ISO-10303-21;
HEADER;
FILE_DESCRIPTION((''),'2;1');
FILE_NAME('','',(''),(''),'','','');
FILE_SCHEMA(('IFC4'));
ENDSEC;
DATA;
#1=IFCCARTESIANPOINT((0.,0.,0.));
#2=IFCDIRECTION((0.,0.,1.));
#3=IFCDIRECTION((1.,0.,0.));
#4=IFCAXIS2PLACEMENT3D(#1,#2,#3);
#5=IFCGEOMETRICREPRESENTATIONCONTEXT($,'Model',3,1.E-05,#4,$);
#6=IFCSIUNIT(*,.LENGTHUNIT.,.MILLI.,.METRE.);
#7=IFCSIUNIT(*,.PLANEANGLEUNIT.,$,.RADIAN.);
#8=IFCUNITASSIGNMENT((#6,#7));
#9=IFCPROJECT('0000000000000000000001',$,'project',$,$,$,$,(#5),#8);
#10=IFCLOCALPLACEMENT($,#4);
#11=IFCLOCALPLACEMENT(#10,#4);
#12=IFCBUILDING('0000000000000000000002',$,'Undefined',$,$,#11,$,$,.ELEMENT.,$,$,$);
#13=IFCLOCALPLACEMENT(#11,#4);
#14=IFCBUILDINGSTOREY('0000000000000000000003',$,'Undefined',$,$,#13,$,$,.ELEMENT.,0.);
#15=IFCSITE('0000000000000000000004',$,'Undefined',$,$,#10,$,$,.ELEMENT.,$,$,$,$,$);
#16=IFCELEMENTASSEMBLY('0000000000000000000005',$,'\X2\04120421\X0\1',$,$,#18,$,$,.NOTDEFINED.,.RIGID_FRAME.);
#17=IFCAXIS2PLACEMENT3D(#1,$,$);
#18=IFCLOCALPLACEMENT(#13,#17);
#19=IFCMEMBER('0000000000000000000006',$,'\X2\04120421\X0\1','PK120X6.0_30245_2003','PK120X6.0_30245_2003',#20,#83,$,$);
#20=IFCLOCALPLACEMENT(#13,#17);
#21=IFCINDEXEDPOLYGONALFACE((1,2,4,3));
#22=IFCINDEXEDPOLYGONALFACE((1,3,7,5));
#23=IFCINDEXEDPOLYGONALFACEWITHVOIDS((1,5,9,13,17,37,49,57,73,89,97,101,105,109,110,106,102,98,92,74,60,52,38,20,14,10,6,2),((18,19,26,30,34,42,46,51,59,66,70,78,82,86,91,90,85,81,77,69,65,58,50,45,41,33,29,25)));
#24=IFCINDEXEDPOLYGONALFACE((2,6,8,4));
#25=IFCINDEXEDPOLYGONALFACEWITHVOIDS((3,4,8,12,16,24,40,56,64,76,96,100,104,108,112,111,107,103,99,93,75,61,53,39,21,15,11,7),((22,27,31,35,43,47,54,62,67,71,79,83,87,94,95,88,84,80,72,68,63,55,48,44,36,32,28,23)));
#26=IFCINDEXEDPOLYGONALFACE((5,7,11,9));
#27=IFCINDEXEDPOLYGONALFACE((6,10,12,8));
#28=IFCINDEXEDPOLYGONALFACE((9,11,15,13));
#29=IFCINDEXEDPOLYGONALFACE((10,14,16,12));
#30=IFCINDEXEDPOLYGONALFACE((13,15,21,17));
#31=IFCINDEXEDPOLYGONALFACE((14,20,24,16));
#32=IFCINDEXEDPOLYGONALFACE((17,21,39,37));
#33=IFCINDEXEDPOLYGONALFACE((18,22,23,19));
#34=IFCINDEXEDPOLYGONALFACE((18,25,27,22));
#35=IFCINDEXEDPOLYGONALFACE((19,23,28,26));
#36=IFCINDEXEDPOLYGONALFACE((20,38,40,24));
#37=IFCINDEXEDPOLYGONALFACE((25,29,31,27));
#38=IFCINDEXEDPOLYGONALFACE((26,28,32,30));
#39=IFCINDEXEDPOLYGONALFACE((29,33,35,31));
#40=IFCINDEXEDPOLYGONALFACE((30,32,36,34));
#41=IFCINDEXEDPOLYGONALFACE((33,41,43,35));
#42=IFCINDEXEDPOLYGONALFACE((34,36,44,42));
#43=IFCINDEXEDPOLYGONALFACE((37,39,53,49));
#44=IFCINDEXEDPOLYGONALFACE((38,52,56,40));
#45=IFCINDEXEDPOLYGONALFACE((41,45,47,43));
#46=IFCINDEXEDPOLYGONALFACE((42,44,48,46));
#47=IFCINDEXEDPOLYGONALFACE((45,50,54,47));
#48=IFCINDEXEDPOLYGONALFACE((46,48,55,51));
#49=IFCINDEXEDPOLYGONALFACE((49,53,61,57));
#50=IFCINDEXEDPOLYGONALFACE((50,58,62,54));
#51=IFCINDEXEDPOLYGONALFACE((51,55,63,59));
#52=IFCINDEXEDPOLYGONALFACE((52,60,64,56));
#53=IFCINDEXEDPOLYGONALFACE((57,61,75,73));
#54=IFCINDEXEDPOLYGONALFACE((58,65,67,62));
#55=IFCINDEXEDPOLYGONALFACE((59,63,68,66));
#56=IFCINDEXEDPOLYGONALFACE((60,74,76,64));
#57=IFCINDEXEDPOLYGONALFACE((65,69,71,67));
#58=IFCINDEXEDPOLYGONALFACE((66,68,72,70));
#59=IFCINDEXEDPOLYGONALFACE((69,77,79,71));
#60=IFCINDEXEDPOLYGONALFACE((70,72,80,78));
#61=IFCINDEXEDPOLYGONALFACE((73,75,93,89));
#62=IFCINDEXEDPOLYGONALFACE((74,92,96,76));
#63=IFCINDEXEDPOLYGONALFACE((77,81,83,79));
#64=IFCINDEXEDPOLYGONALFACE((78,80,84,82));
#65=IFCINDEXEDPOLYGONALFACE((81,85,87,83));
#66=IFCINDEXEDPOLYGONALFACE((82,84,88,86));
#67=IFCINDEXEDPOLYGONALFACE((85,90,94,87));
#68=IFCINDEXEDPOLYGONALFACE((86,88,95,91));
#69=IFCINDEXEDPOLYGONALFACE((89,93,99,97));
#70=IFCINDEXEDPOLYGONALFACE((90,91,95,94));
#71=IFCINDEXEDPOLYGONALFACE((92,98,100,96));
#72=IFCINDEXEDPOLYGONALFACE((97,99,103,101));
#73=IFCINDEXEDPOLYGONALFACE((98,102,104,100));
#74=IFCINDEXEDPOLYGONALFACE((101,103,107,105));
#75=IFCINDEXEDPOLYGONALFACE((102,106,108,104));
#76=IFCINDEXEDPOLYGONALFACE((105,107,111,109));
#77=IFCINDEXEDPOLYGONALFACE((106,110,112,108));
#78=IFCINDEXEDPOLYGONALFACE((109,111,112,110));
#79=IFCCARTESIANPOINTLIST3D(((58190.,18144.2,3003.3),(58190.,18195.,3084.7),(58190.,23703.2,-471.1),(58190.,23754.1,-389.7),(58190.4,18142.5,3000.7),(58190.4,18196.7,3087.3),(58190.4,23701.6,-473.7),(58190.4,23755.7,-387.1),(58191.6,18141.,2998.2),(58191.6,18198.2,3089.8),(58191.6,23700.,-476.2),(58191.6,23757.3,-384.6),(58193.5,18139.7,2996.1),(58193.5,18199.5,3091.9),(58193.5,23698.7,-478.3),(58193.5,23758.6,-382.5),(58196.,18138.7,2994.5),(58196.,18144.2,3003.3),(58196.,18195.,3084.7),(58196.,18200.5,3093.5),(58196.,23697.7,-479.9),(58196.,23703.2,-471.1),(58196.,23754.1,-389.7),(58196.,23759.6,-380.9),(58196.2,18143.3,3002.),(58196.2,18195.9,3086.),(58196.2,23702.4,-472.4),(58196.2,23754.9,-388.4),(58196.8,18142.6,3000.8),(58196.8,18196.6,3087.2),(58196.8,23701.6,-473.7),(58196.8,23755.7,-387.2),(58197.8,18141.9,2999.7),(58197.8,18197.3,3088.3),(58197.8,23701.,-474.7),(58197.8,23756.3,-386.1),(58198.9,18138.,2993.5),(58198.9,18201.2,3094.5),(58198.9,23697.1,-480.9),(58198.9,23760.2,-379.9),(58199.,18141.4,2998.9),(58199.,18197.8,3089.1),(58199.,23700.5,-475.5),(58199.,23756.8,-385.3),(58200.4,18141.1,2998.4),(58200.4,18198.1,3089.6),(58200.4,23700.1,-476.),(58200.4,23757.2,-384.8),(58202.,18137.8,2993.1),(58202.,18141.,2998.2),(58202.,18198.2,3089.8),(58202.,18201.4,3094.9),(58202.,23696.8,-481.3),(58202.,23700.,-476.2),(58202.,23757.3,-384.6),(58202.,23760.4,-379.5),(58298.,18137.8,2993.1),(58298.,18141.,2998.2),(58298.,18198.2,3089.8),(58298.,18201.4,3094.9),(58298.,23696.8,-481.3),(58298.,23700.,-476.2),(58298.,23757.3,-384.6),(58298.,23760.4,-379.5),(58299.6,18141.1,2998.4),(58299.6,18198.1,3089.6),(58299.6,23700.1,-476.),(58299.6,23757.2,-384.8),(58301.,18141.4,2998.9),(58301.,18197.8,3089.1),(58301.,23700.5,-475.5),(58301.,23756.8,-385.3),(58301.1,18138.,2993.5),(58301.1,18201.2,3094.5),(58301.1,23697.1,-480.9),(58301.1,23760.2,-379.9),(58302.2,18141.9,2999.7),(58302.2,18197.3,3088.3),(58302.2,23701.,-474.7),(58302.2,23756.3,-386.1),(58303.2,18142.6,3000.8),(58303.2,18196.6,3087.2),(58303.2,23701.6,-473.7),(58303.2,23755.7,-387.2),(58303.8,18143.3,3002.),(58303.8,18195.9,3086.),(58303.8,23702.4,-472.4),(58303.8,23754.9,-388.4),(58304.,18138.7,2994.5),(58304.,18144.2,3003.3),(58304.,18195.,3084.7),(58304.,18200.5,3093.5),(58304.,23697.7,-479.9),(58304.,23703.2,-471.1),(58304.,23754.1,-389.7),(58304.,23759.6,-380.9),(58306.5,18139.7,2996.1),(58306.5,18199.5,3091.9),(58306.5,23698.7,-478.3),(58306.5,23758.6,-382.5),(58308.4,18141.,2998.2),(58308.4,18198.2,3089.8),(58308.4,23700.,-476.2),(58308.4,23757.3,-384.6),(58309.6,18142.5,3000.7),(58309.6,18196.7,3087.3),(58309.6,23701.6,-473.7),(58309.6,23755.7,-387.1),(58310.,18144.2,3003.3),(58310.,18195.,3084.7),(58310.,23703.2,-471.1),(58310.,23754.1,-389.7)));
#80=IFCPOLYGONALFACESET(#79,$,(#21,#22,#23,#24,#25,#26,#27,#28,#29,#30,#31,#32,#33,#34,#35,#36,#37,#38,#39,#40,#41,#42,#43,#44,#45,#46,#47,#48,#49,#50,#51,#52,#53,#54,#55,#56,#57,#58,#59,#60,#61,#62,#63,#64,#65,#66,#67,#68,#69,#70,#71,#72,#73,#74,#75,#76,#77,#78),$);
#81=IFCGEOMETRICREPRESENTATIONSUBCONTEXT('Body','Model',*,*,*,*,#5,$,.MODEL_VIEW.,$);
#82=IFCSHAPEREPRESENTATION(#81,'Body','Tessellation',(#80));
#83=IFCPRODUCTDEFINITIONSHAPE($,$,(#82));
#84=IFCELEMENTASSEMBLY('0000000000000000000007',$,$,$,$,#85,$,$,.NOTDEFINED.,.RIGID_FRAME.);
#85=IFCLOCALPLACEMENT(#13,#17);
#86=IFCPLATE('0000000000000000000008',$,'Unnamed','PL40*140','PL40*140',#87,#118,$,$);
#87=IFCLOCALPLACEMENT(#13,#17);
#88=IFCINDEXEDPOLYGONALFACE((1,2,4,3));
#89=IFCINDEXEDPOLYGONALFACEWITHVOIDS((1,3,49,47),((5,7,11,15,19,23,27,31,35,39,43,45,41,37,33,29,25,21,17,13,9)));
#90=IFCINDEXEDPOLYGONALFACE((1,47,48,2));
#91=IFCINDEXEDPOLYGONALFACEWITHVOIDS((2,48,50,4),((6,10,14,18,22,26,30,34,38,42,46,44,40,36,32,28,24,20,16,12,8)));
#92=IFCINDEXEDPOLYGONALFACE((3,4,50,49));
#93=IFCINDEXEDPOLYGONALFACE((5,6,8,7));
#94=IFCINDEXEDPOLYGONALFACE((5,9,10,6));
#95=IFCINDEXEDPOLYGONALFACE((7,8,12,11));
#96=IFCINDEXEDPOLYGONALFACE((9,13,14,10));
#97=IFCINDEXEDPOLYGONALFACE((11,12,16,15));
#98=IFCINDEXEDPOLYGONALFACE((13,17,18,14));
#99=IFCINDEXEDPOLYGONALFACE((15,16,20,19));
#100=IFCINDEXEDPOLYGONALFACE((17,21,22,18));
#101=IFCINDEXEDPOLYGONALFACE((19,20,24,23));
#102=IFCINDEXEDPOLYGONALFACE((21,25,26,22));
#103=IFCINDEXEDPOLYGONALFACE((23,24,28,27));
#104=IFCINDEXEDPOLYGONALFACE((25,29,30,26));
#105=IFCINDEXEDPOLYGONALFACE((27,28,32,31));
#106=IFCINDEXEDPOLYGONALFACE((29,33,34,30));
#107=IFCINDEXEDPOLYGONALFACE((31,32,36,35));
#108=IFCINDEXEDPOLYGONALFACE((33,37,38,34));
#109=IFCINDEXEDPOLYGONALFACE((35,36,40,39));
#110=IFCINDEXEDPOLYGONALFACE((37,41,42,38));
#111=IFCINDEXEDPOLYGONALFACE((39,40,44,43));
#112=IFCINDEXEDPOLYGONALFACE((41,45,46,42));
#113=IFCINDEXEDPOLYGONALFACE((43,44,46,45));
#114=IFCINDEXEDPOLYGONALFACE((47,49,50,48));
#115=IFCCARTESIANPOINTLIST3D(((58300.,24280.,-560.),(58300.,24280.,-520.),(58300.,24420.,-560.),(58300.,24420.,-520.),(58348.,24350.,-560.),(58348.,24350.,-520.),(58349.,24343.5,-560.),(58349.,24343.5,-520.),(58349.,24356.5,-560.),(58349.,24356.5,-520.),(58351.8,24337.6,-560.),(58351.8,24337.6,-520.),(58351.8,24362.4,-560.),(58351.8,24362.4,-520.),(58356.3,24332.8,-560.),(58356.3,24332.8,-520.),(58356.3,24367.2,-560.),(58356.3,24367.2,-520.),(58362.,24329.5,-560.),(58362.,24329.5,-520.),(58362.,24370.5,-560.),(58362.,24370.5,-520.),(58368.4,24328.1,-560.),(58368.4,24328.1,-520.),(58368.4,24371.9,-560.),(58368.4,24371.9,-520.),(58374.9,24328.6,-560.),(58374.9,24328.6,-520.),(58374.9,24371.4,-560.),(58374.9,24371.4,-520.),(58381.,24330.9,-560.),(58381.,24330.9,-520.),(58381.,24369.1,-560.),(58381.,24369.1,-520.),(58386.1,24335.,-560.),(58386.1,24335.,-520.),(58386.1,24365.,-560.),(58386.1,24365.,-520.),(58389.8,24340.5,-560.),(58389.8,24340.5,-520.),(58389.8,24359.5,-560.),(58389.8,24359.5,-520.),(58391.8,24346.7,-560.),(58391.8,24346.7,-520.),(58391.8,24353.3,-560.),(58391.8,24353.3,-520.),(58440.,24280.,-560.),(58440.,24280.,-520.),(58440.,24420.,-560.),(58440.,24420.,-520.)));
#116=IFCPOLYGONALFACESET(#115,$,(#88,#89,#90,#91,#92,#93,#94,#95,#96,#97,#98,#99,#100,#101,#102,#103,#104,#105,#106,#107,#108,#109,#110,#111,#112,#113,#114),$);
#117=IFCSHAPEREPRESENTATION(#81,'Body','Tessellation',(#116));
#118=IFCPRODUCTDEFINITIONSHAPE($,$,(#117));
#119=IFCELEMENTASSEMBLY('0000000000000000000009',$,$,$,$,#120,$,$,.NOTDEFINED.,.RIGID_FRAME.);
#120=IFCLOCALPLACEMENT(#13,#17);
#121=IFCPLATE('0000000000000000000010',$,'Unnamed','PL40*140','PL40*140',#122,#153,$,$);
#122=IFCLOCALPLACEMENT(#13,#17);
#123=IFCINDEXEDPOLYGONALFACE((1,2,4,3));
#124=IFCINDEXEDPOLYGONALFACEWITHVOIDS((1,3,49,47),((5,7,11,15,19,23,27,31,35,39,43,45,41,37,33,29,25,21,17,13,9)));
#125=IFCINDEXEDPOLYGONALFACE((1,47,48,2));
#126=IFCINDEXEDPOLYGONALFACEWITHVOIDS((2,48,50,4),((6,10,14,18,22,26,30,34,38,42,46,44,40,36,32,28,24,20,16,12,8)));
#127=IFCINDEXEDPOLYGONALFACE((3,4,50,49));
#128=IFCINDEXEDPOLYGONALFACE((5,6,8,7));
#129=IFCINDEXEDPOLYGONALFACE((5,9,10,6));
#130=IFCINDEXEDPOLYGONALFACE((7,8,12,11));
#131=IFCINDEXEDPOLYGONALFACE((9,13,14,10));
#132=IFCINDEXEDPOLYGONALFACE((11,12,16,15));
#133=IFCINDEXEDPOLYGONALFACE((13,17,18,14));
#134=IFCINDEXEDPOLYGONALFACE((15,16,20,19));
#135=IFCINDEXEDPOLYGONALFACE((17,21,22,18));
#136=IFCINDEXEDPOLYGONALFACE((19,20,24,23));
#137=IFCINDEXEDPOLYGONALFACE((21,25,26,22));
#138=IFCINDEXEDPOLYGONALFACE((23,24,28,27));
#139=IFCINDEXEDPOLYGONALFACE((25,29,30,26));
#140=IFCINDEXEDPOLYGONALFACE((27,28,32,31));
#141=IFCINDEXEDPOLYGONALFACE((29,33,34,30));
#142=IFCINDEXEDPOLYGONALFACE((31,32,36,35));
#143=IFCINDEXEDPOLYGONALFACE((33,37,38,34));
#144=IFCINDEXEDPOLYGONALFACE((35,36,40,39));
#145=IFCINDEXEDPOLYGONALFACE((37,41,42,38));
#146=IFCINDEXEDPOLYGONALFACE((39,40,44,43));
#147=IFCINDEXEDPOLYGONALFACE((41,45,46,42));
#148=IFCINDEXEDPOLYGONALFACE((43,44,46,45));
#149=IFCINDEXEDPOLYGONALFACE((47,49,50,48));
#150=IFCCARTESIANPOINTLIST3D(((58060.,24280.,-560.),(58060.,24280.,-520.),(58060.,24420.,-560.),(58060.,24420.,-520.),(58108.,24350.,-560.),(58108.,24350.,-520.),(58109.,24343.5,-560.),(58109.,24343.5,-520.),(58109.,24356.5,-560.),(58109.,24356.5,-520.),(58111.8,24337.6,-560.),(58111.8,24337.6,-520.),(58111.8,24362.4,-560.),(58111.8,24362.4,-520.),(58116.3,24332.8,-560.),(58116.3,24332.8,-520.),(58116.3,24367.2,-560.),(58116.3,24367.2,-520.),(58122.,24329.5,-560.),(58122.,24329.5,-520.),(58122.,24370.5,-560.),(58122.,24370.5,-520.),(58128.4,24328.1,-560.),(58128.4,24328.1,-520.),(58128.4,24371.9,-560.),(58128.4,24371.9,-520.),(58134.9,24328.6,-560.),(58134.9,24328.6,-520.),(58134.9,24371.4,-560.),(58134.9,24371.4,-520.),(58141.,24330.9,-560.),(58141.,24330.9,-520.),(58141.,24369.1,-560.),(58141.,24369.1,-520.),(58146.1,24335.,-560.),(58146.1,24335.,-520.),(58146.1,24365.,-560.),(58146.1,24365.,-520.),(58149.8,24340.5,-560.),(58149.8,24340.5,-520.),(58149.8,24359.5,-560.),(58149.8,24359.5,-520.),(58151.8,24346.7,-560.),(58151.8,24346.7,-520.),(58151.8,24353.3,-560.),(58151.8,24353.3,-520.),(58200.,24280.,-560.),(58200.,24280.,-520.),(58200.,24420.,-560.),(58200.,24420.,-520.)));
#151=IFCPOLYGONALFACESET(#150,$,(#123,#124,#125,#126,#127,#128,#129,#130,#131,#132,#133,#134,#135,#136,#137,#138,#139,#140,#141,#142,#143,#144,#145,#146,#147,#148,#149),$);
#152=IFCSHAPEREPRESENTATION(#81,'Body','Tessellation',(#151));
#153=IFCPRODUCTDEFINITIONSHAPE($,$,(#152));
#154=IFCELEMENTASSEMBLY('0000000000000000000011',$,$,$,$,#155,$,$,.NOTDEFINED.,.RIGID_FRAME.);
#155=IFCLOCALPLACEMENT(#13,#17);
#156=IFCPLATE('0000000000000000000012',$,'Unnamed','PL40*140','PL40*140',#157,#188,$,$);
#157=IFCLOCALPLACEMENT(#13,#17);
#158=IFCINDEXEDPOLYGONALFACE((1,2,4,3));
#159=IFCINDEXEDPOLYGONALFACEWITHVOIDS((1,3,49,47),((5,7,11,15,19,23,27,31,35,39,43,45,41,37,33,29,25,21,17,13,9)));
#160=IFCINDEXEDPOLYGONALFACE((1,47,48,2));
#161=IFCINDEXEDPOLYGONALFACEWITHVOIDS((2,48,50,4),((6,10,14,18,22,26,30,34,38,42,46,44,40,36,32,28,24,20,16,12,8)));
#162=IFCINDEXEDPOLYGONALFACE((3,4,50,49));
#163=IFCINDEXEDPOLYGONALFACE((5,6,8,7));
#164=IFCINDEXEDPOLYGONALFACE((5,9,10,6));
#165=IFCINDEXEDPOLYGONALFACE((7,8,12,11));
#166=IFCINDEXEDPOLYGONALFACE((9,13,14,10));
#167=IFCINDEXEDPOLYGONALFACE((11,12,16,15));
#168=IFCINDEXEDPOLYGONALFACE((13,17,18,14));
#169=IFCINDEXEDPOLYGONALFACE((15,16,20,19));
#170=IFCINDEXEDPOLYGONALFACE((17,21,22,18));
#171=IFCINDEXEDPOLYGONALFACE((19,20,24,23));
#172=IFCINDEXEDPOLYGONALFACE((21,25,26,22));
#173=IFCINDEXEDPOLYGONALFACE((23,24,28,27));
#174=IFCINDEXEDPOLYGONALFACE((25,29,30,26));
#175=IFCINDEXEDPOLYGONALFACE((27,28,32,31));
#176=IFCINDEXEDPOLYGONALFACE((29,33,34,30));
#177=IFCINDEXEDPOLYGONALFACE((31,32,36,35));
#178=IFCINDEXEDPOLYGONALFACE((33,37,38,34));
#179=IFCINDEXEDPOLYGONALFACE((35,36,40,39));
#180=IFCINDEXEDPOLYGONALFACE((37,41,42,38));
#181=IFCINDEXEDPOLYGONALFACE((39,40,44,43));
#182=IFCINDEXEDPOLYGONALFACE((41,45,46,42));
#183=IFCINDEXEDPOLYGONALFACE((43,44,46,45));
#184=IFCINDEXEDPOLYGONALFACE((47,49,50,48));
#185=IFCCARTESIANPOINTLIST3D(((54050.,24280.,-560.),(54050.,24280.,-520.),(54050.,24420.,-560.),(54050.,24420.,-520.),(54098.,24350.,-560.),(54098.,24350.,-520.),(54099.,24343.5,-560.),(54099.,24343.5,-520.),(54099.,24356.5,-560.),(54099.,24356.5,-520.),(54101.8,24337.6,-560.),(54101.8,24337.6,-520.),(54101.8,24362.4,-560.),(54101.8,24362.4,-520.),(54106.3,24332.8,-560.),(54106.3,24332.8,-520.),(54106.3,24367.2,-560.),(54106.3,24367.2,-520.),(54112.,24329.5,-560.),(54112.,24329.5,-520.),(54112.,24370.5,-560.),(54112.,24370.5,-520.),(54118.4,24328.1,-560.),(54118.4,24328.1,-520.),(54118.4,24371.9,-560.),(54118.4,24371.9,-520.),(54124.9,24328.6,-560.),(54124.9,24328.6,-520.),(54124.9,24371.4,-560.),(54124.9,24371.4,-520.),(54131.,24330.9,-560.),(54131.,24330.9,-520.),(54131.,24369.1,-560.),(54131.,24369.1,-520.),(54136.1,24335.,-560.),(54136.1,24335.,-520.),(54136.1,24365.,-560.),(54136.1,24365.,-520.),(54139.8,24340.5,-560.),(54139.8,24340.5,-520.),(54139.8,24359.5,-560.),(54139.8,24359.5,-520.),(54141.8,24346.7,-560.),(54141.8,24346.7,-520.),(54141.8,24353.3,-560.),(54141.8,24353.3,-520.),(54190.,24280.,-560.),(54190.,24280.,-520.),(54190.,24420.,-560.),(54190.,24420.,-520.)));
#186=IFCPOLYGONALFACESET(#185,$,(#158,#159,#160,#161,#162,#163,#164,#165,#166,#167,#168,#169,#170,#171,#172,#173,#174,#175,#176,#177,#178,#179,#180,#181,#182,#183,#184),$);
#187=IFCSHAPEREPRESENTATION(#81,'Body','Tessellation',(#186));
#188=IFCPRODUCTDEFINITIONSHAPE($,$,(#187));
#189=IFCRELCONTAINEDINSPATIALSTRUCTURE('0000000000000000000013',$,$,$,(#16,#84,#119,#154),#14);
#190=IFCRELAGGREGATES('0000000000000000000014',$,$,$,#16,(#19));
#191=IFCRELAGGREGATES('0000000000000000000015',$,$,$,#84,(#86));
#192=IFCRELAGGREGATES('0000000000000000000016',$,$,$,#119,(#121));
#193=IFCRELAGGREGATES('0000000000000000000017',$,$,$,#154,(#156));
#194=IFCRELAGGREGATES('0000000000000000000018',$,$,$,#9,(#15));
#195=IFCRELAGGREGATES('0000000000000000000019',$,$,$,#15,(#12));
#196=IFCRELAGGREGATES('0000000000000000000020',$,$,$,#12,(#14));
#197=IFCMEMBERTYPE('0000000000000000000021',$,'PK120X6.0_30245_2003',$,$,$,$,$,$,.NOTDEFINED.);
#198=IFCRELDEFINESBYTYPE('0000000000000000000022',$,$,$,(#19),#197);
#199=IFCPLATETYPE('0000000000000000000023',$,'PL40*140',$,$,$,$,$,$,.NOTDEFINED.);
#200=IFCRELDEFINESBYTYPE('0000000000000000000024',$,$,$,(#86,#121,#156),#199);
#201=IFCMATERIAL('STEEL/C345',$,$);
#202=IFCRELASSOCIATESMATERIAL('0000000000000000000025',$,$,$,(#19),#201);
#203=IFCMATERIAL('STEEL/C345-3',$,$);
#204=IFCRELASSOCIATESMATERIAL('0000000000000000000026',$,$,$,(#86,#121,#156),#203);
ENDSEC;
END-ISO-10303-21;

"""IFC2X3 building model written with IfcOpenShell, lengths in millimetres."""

from ifc_helpers import new_model, si_unit, frame, origin_with_axes, origin_2d_with_axis, place, context, subcontext, project, spatial, polyline, hollow_rectangle, circle, outline, extrude, boolean, material, type_object, element, aggregate, save


model = new_model("IFC2X3")

# Units and contexts
model_context = context("Model", 3, precision=1e-05, world=origin_with_axes())
body_context = subcontext(model_context, "Body", "Model", "MODEL_VIEW")
ifc_project = project(units=[si_unit("LENGTHUNIT", "METRE", prefix="MILLI"), si_unit("PLANEANGLEUNIT", "RADIAN")], contexts=[model_context])

# Site, building, storey
site_placement = place(None, origin_with_axes())
site = spatial("IfcSite", under=ifc_project, at=site_placement, Name="Undefined", CompositionType="ELEMENT")
building_placement = place(site_placement, origin_with_axes())
building = spatial("IfcBuilding", under=site, at=building_placement, Name="Undefined", CompositionType="ELEMENT")
storey_placement = place(building_placement, origin_with_axes())
storey = spatial("IfcBuildingStorey", under=building, at=storey_placement, Name="Undefined", CompositionType="ELEMENT", Elevation=0.0)

# Shared definitions
ifc_material_1 = material(Name="STEEL/C345-3")

# Element assembly, member
assembly_1_placement = place(storey_placement, origin_with_axes())
assembly_1 = element("IfcElementAssembly", 1, at=assembly_1_placement, inside=storey, Name="ВС1", AssemblyPlace="NOTDEFINED", PredefinedType="RIGID_FRAME")
ifc_material_2 = material(Name="STEEL/C345")
member_type_1 = type_object("IfcMemberType", Name="PK120X6.0_30245_2003", PredefinedType="NOTDEFINED")
member_1_placement = place(assembly_1_placement, frame((58250.0, 23728.6, -430.4), z_axis=(1.0, 0.0, 0.0), x_axis=(0.0, -0.847998, 0.529999)))
member_1 = element("IfcMember", 2, at=member_1_placement, type_object=member_type_1, material=ifc_material_2, Name="ВС1", Description="PK120X6.0_30245_2003", ObjectType="PK120X6.0_30245_2003", context=body_context, shape_type="SweptSolid", body=[
    extrude(hollow_rectangle(XDim=120.0, YDim=120.0, WallThickness=6.0, InnerFilletRadius=6.0, OuterFilletRadius=12.0, at=origin_2d_with_axis()), frame((6555.5, 0.0, 0.0), z_axis=(-1.0, 0.0, 0.0), x_axis=(0.0, -1.0, 0.0)), (0.0, 0.0, 1.0), 6555.5),
])
aggregate(assembly_1, [member_1])

# Element assemblies, plates
assembly_2_placement = place(storey_placement, origin_with_axes())
assembly_2 = element("IfcElementAssembly", 3, at=assembly_2_placement, inside=storey, AssemblyPlace="NOTDEFINED", PredefinedType="RIGID_FRAME")
plate_type = type_object("IfcPlateType", Name="PL40*140", PredefinedType="NOTDEFINED")
plate_1_placement = place(assembly_2_placement, frame((58300.0, 24280.0, -540.0), z_axis=(0.0, 0.0, -1.0), x_axis=(0.0, 1.0, 0.0)))
plate_1 = element("IfcPlate", 4, at=plate_1_placement, type_object=plate_type, material=ifc_material_1, Name="Unnamed", Description="PL40*140", ObjectType="PL40*140", context=body_context, shape_type="CSG", body=[
    boolean("DIFFERENCE", extrude(outline(polyline([(0.0, 0.0), (140.0, 0.0), (140.0, 140.0), (0.0, 140.0), (0.0, 0.0)])), frame((0.0, 0.0, -20.0), z_axis=(0.0, 0.0, 1.0), x_axis=(1.0, 0.0, 0.0)), (0.0, 0.0, 1.0), 40.0), extrude(circle(Radius=22.0, at=origin_2d_with_axis()), frame((70.0, 70.0, -40.0), z_axis=(0.0, 0.0, 1.0), x_axis=(0.0, -1.0, 0.0)), (0.0, 0.0, 1.0), 80.0)),
])
aggregate(assembly_2, [plate_1])
assembly_3_placement = place(storey_placement, origin_with_axes())
assembly_3 = element("IfcElementAssembly", 5, at=assembly_3_placement, inside=storey, AssemblyPlace="NOTDEFINED", PredefinedType="RIGID_FRAME")
plate_2_placement = place(assembly_3_placement, frame((58060.0, 24280.0, -540.0), z_axis=(0.0, 0.0, -1.0), x_axis=(0.0, 1.0, 0.0)))
plate_2 = element("IfcPlate", 6, at=plate_2_placement, type_object=plate_type, material=ifc_material_1, Name="Unnamed", Description="PL40*140", ObjectType="PL40*140", context=body_context, shape_type="CSG", body=[
    boolean("DIFFERENCE", extrude(outline(polyline([(0.0, 0.0), (140.0, 0.0), (140.0, 140.0), (0.0, 140.0), (0.0, 0.0)])), frame((0.0, 0.0, -20.0), z_axis=(0.0, 0.0, 1.0), x_axis=(1.0, 0.0, 0.0)), (0.0, 0.0, 1.0), 40.0), extrude(circle(Radius=22.0, at=origin_2d_with_axis()), frame((70.0, 70.0, -40.0), z_axis=(0.0, 0.0, 1.0), x_axis=(0.0, -1.0, 0.0)), (0.0, 0.0, 1.0), 80.0)),
])
aggregate(assembly_3, [plate_2])
assembly_4_placement = place(storey_placement, origin_with_axes())
assembly_4 = element("IfcElementAssembly", 7, at=assembly_4_placement, inside=storey, AssemblyPlace="NOTDEFINED", PredefinedType="RIGID_FRAME")
plate_3_placement = place(assembly_4_placement, frame((54190.0, 24280.0, -540.0), z_axis=(0.0, 0.0, 1.0), x_axis=(0.0, 1.0, 0.0)))
plate_3 = element("IfcPlate", 8, at=plate_3_placement, type_object=plate_type, material=ifc_material_1, Name="Unnamed", Description="PL40*140", ObjectType="PL40*140", context=body_context, shape_type="CSG", body=[
    boolean("DIFFERENCE", extrude(outline(polyline([(0.0, 0.0), (140.0, 0.0), (140.0, 140.0), (0.0, 140.0), (0.0, 0.0)])), frame((0.0, 0.0, -20.0), z_axis=(0.0, 0.0, 1.0), x_axis=(1.0, 0.0, 0.0)), (0.0, 0.0, 1.0), 40.0), extrude(circle(Radius=22.0, at=origin_2d_with_axis()), frame((70.0, 70.0, 40.0), z_axis=(0.0, 0.0, -1.0), x_axis=(0.0, 1.0, 0.0)), (0.0, 0.0, 1.0), 80.0)),
])
aggregate(assembly_4, [plate_3])

save(model, "model.ifc")
